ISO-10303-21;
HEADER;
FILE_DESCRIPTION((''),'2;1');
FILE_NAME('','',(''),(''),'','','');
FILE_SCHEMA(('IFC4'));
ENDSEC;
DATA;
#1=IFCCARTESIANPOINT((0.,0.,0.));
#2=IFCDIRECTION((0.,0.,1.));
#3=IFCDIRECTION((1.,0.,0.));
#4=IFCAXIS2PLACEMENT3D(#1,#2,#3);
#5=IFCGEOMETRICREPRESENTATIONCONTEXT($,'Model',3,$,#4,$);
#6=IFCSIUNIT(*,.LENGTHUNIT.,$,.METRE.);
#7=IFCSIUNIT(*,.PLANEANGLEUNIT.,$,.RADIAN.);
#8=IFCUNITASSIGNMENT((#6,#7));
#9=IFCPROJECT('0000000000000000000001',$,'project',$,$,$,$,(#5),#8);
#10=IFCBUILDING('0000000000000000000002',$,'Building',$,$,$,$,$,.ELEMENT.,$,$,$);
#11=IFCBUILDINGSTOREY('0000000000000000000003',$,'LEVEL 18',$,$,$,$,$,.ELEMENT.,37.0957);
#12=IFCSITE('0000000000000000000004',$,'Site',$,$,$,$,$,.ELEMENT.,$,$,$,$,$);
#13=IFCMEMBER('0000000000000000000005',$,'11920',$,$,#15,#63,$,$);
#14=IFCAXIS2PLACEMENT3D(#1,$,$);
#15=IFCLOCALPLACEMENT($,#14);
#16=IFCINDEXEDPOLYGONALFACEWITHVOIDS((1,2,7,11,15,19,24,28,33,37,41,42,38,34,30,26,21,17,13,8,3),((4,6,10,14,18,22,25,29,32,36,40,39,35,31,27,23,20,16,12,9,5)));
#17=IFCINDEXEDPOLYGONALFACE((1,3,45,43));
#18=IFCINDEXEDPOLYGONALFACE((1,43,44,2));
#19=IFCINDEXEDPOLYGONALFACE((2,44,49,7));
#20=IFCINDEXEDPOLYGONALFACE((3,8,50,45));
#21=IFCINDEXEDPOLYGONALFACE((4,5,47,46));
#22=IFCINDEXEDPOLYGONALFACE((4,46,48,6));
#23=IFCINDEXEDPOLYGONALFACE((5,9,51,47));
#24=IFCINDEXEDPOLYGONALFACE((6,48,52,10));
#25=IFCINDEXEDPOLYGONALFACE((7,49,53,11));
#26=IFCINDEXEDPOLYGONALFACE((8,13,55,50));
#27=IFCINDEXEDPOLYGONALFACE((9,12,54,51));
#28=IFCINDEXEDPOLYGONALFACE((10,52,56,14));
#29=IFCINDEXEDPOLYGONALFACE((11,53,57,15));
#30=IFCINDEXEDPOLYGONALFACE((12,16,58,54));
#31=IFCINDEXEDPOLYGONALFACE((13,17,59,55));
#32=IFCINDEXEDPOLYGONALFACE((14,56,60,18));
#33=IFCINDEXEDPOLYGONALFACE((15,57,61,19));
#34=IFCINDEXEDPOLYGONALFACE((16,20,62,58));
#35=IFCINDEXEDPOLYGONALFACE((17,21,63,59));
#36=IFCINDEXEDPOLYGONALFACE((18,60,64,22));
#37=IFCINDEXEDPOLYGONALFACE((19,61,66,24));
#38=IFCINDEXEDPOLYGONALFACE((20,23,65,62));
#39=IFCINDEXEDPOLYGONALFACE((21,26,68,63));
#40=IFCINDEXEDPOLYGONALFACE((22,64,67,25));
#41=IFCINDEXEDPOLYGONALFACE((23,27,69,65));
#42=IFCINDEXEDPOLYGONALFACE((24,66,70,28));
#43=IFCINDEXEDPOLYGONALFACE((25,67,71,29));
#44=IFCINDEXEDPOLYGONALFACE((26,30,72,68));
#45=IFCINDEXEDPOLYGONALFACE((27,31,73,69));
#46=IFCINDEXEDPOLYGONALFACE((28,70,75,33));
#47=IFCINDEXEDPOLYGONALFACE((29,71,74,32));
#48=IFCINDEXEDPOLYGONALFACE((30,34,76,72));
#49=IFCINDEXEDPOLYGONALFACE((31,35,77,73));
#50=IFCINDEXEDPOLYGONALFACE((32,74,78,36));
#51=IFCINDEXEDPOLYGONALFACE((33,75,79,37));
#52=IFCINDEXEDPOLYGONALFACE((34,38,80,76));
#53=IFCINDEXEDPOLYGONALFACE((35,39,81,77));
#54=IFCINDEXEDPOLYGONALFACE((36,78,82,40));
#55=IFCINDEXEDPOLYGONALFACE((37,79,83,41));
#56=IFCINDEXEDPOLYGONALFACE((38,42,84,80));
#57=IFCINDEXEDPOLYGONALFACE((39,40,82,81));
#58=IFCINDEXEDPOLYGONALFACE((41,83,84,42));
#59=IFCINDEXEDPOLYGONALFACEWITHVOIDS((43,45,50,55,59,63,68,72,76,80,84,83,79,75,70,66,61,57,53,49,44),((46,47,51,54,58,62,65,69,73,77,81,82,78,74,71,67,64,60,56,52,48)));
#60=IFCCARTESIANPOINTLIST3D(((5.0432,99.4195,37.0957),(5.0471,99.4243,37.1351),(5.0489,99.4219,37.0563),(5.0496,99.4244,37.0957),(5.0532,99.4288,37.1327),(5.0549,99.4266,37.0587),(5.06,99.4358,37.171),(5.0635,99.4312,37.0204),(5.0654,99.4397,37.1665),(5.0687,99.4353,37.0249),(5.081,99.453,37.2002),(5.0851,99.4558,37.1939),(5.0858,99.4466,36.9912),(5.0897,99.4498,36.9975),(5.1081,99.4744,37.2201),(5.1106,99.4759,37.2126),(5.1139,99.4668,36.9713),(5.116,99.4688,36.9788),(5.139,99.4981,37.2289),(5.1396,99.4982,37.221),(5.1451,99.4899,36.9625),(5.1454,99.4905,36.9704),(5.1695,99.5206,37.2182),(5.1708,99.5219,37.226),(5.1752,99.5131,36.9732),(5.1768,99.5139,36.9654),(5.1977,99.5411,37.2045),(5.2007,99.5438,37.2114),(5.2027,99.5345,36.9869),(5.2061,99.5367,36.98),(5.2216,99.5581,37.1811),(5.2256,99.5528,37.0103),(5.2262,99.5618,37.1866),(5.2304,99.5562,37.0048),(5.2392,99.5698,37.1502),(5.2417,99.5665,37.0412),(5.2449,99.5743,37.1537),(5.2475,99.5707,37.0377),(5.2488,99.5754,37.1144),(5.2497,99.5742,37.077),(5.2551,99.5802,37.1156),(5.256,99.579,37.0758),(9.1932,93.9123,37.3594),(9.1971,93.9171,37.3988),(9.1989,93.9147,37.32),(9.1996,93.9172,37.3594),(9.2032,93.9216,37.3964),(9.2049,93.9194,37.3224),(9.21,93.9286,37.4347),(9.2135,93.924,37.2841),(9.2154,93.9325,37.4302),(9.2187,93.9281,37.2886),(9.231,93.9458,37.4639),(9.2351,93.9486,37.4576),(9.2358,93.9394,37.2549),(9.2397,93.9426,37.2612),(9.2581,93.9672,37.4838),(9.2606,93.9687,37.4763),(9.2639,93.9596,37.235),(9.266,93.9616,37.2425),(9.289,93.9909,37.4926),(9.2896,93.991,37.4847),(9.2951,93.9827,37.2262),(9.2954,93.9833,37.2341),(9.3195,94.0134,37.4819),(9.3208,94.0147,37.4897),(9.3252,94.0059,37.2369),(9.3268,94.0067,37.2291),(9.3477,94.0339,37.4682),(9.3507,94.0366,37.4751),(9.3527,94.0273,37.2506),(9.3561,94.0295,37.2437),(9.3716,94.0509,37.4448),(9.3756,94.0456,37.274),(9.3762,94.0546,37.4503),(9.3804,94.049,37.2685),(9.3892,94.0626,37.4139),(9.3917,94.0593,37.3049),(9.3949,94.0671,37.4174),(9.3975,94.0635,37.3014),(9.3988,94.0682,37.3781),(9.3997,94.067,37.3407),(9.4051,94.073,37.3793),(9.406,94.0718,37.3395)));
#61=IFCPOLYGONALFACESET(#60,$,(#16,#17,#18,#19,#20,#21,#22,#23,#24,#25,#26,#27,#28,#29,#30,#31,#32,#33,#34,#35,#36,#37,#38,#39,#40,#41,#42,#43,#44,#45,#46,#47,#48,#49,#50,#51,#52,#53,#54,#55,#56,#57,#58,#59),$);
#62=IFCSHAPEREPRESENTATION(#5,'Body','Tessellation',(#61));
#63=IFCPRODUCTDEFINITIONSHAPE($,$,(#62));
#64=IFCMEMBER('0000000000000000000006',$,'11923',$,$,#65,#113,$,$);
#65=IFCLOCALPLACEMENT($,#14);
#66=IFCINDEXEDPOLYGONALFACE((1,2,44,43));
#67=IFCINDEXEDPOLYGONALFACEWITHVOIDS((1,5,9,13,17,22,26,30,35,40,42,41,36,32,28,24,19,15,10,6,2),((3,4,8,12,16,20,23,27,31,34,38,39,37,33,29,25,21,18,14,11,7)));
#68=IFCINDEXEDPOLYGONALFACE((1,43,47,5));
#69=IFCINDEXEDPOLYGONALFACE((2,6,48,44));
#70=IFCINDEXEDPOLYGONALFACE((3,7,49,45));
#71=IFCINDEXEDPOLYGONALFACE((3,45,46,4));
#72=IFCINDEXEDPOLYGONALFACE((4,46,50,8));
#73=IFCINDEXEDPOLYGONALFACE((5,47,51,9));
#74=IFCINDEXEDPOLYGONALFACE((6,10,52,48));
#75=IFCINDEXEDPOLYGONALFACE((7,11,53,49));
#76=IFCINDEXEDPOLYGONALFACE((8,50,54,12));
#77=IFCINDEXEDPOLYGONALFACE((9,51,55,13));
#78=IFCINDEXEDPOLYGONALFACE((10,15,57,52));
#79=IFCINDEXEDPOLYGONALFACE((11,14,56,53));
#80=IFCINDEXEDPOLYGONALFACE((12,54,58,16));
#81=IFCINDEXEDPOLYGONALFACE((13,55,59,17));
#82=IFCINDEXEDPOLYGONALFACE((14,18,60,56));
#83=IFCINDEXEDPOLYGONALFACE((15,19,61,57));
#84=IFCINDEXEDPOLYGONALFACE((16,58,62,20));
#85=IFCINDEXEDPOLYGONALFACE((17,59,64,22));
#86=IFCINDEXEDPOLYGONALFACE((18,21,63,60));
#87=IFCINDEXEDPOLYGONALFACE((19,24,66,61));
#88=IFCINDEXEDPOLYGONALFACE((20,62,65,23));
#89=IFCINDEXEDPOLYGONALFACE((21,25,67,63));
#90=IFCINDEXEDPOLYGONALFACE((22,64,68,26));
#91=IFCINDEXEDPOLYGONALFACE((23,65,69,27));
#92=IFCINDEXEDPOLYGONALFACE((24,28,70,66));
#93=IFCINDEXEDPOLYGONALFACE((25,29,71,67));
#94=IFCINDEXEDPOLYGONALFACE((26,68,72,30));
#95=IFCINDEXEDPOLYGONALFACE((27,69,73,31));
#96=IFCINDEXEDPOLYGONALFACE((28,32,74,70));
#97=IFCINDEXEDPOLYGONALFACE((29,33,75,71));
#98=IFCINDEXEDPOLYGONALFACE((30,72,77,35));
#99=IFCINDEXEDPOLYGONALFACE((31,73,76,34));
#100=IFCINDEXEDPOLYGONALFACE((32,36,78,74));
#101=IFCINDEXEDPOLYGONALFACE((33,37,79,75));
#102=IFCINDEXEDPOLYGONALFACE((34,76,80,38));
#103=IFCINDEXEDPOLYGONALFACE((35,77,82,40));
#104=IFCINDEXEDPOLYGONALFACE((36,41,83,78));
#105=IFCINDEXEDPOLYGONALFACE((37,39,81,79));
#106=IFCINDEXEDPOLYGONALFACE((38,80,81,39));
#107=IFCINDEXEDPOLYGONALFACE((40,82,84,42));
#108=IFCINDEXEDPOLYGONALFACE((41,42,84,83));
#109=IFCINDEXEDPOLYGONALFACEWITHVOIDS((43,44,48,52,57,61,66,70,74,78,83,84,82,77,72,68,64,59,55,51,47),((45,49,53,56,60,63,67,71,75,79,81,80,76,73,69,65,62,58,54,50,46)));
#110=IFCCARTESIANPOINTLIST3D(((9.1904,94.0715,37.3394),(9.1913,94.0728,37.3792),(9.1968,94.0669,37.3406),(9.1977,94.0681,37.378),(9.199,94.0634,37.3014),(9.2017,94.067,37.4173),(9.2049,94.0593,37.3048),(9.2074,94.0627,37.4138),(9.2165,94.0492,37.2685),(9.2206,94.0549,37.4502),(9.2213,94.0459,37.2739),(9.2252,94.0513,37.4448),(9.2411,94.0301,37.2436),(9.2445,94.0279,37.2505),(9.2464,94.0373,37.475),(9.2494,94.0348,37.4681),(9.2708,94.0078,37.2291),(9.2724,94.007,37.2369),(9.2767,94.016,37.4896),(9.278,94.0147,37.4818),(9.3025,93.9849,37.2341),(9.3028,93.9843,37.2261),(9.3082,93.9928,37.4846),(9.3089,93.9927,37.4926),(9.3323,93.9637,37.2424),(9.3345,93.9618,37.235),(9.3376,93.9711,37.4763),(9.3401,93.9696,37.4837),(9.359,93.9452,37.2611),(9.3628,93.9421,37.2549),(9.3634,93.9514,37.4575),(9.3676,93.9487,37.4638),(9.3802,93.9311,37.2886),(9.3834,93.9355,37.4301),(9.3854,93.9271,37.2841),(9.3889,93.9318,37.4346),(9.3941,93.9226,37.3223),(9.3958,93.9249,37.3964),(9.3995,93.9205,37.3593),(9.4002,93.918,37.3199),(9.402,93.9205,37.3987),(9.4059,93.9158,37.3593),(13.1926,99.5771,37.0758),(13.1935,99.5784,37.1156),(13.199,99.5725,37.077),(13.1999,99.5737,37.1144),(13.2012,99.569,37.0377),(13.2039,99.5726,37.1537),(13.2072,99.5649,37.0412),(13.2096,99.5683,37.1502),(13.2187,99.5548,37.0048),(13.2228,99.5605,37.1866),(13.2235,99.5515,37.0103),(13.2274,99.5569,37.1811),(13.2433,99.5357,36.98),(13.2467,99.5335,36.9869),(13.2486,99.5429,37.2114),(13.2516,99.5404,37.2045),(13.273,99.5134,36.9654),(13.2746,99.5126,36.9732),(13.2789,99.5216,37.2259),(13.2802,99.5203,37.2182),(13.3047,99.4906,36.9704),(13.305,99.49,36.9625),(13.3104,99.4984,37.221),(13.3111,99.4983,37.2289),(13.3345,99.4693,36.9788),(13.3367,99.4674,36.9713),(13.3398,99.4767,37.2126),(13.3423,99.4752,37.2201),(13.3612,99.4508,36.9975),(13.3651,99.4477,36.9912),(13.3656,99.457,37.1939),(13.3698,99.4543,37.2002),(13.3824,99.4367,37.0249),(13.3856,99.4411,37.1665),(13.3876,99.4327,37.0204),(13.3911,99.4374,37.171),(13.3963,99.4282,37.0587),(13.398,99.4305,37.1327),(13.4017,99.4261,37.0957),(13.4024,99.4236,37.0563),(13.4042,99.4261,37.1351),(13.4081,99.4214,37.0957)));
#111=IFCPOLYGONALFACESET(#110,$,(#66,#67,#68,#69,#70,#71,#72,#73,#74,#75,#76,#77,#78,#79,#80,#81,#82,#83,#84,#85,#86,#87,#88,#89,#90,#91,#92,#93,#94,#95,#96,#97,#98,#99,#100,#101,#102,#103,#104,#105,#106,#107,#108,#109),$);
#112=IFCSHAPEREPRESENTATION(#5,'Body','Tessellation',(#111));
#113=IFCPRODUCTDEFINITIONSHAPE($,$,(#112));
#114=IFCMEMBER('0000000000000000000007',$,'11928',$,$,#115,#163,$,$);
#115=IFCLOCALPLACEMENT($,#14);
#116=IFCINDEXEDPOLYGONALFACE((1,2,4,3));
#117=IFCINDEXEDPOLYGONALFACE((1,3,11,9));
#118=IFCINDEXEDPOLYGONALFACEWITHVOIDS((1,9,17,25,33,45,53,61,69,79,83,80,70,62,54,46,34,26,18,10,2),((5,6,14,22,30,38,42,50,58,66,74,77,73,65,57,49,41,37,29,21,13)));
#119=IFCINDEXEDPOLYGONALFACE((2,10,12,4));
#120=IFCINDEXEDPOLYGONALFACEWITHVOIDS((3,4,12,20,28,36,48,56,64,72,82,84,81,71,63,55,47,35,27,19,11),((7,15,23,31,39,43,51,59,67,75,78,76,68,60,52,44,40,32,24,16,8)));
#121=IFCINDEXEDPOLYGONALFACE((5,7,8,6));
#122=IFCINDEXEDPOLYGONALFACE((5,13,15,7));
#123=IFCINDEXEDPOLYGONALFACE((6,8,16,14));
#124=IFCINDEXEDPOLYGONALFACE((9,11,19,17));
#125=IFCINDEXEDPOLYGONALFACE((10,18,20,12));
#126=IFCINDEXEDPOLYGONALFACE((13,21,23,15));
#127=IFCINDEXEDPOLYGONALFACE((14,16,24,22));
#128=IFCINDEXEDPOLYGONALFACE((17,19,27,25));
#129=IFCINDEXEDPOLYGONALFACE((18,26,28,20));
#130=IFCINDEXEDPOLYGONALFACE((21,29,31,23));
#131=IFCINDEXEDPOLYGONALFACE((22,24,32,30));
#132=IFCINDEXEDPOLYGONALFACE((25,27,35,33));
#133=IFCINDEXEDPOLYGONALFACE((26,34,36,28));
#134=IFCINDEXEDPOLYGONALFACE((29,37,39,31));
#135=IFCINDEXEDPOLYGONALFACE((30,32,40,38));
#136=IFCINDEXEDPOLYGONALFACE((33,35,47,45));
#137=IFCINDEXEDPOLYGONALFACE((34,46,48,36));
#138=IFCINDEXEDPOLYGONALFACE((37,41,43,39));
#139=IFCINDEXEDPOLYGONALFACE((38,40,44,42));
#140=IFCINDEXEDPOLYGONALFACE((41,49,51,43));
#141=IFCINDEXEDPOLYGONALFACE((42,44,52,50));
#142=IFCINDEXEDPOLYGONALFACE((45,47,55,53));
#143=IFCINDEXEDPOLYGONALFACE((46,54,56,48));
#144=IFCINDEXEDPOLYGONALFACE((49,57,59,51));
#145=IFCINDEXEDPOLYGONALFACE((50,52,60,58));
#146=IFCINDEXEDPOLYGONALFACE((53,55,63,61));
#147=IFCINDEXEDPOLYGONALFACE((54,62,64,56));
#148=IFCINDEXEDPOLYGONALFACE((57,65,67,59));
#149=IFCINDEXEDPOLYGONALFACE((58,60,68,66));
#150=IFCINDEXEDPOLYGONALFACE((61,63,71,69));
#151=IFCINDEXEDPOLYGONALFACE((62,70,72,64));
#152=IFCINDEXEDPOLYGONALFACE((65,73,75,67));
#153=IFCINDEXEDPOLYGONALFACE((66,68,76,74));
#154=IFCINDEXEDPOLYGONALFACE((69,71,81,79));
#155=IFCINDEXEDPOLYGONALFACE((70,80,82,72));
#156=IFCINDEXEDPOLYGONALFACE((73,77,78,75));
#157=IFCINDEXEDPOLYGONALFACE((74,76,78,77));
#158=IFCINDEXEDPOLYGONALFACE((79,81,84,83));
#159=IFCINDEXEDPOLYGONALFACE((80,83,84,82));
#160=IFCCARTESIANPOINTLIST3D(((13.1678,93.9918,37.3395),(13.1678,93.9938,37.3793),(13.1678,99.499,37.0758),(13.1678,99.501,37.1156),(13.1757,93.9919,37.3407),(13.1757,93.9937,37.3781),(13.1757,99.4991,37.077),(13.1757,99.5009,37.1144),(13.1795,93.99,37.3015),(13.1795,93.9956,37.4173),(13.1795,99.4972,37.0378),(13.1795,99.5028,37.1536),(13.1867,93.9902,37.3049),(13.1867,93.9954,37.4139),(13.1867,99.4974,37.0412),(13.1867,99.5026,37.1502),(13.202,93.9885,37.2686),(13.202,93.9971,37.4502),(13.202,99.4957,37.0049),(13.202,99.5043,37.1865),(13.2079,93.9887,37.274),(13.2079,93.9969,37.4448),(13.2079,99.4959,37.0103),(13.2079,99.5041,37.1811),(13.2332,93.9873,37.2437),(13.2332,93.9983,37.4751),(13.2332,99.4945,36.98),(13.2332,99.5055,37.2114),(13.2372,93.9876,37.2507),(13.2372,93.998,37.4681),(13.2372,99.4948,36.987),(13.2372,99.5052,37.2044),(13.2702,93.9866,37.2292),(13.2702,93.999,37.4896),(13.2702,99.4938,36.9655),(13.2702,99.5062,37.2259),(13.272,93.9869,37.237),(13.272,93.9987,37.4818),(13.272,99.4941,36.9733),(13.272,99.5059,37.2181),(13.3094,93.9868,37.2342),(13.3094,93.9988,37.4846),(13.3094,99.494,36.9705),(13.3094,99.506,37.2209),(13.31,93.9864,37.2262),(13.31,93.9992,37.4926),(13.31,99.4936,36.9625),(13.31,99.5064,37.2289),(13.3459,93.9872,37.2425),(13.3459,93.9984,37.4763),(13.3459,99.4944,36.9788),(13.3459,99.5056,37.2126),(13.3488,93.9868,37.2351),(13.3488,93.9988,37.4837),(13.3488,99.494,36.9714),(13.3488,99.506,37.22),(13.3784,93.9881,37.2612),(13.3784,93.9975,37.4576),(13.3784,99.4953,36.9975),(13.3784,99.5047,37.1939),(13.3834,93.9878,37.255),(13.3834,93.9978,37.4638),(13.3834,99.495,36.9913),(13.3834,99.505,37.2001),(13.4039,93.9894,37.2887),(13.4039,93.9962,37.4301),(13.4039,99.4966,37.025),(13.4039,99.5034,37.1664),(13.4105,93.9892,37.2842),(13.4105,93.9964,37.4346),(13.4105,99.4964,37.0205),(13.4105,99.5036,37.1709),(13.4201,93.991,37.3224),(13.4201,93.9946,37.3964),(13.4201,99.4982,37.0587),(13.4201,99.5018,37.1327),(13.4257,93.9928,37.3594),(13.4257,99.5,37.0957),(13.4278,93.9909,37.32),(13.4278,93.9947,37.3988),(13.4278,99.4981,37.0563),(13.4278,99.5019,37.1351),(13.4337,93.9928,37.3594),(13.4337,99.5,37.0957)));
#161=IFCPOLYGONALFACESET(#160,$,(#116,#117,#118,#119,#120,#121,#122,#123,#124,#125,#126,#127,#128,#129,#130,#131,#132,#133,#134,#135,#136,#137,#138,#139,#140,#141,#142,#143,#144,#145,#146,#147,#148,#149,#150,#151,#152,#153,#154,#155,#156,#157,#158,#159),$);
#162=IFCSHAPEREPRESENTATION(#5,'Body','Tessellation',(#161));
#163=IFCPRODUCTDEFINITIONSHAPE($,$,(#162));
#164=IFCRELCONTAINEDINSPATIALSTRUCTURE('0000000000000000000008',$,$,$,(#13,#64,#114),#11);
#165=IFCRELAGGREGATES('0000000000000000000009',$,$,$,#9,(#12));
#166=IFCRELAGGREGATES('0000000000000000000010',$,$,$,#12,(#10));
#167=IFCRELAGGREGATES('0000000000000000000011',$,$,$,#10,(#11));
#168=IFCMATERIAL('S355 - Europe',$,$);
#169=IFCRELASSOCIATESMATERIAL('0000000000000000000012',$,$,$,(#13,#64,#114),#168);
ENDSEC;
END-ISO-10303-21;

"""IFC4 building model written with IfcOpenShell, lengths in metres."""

from ifc_helpers import new_model, si_unit, frame, origin_with_axes, origin_2d_with_axis, place, context, project, spatial, hollow_circle, extrude, material, material_profile, profile_set, profile_usage, element, save


model = new_model("IFC4")

# Units and contexts
model_context = context("Model", 3, world=origin_with_axes())
ifc_project = project(units=[si_unit("LENGTHUNIT", "METRE"), si_unit("PLANEANGLEUNIT", "RADIAN")], contexts=[model_context])

# Site, building, storey
site = spatial("IfcSite", under=ifc_project, Name="Site", CompositionType="ELEMENT")
building = spatial("IfcBuilding", under=site, Name="Building", CompositionType="ELEMENT")
storey = spatial("IfcBuildingStorey", under=building, Name="LEVEL 18", CompositionType="ELEMENT", Elevation=37.0957)

# Shared definitions
ifc_material = material(Name="S355 - Europe")

# Members
ifc_material_profile_1 = material_profile(ifc_material, hollow_circle(Radius=0.1337, WallThickness=0.008, at=origin_2d_with_axis()))
ifc_profile_set_1 = profile_set([ifc_material_profile_1])
ifc_profile_usage_1 = profile_usage(ifc_profile_set_1, cardinal=10)
member_1_placement = place(None, frame((9.3, 93.9928, 37.3594), z_axis=(-0.601378, 0.79805, -0.038213), x_axis=(-0.798681, -0.601755, 0.0)))
element("IfcMember", 1, at=member_1_placement, inside=storey, material=ifc_profile_usage_1, Name="11920", context=model_context, shape_type="SweptSolid", body=[
    extrude(hollow_circle(Radius=0.1337, WallThickness=0.008, at=origin_2d_with_axis()), origin_with_axes(), (0.0, 0.0, 1.0), 6.9008),
])
ifc_material_profile_2 = material_profile(ifc_material, hollow_circle(Radius=0.1337, WallThickness=0.008, at=origin_2d_with_axis()))
ifc_profile_set_2 = profile_set([ifc_material_profile_2])
ifc_profile_usage_2 = profile_usage(ifc_profile_set_2, cardinal=10)
member_2_placement = place(None, frame((13.3, 99.5, 37.0957), z_axis=(-0.587551, -0.808261, 0.038702), x_axis=(0.809096, -0.587676, 0.0)))
element("IfcMember", 2, at=member_2_placement, inside=storey, material=ifc_profile_usage_2, Name="11923", context=model_context, shape_type="SweptSolid", body=[
    extrude(hollow_circle(Radius=0.1337, WallThickness=0.008, at=origin_2d_with_axis()), origin_with_axes(), (0.0, 0.0, 1.0), 6.8117),
])
ifc_material_profile_3 = material_profile(ifc_material, hollow_circle(Radius=0.1337, WallThickness=0.008, at=origin_2d_with_axis()))
ifc_profile_set_3 = profile_set([ifc_material_profile_3])
ifc_profile_usage_3 = profile_usage(ifc_profile_set_3, cardinal=10)
member_3_placement = place(None, frame((13.3, 99.5, 37.0957), z_axis=(0.0, -0.998856, 0.047828), x_axis=(1.0, 0.0, 0.0)))
element("IfcMember", 3, at=member_3_placement, inside=storey, material=ifc_profile_usage_3, Name="11928", context=model_context, shape_type="SweptSolid", body=[
    extrude(hollow_circle(Radius=0.1337, WallThickness=0.008, at=origin_2d_with_axis()), origin_with_axes(), (0.0, 0.0, 1.0), 5.5135),
])

save(model, "model.ifc")
